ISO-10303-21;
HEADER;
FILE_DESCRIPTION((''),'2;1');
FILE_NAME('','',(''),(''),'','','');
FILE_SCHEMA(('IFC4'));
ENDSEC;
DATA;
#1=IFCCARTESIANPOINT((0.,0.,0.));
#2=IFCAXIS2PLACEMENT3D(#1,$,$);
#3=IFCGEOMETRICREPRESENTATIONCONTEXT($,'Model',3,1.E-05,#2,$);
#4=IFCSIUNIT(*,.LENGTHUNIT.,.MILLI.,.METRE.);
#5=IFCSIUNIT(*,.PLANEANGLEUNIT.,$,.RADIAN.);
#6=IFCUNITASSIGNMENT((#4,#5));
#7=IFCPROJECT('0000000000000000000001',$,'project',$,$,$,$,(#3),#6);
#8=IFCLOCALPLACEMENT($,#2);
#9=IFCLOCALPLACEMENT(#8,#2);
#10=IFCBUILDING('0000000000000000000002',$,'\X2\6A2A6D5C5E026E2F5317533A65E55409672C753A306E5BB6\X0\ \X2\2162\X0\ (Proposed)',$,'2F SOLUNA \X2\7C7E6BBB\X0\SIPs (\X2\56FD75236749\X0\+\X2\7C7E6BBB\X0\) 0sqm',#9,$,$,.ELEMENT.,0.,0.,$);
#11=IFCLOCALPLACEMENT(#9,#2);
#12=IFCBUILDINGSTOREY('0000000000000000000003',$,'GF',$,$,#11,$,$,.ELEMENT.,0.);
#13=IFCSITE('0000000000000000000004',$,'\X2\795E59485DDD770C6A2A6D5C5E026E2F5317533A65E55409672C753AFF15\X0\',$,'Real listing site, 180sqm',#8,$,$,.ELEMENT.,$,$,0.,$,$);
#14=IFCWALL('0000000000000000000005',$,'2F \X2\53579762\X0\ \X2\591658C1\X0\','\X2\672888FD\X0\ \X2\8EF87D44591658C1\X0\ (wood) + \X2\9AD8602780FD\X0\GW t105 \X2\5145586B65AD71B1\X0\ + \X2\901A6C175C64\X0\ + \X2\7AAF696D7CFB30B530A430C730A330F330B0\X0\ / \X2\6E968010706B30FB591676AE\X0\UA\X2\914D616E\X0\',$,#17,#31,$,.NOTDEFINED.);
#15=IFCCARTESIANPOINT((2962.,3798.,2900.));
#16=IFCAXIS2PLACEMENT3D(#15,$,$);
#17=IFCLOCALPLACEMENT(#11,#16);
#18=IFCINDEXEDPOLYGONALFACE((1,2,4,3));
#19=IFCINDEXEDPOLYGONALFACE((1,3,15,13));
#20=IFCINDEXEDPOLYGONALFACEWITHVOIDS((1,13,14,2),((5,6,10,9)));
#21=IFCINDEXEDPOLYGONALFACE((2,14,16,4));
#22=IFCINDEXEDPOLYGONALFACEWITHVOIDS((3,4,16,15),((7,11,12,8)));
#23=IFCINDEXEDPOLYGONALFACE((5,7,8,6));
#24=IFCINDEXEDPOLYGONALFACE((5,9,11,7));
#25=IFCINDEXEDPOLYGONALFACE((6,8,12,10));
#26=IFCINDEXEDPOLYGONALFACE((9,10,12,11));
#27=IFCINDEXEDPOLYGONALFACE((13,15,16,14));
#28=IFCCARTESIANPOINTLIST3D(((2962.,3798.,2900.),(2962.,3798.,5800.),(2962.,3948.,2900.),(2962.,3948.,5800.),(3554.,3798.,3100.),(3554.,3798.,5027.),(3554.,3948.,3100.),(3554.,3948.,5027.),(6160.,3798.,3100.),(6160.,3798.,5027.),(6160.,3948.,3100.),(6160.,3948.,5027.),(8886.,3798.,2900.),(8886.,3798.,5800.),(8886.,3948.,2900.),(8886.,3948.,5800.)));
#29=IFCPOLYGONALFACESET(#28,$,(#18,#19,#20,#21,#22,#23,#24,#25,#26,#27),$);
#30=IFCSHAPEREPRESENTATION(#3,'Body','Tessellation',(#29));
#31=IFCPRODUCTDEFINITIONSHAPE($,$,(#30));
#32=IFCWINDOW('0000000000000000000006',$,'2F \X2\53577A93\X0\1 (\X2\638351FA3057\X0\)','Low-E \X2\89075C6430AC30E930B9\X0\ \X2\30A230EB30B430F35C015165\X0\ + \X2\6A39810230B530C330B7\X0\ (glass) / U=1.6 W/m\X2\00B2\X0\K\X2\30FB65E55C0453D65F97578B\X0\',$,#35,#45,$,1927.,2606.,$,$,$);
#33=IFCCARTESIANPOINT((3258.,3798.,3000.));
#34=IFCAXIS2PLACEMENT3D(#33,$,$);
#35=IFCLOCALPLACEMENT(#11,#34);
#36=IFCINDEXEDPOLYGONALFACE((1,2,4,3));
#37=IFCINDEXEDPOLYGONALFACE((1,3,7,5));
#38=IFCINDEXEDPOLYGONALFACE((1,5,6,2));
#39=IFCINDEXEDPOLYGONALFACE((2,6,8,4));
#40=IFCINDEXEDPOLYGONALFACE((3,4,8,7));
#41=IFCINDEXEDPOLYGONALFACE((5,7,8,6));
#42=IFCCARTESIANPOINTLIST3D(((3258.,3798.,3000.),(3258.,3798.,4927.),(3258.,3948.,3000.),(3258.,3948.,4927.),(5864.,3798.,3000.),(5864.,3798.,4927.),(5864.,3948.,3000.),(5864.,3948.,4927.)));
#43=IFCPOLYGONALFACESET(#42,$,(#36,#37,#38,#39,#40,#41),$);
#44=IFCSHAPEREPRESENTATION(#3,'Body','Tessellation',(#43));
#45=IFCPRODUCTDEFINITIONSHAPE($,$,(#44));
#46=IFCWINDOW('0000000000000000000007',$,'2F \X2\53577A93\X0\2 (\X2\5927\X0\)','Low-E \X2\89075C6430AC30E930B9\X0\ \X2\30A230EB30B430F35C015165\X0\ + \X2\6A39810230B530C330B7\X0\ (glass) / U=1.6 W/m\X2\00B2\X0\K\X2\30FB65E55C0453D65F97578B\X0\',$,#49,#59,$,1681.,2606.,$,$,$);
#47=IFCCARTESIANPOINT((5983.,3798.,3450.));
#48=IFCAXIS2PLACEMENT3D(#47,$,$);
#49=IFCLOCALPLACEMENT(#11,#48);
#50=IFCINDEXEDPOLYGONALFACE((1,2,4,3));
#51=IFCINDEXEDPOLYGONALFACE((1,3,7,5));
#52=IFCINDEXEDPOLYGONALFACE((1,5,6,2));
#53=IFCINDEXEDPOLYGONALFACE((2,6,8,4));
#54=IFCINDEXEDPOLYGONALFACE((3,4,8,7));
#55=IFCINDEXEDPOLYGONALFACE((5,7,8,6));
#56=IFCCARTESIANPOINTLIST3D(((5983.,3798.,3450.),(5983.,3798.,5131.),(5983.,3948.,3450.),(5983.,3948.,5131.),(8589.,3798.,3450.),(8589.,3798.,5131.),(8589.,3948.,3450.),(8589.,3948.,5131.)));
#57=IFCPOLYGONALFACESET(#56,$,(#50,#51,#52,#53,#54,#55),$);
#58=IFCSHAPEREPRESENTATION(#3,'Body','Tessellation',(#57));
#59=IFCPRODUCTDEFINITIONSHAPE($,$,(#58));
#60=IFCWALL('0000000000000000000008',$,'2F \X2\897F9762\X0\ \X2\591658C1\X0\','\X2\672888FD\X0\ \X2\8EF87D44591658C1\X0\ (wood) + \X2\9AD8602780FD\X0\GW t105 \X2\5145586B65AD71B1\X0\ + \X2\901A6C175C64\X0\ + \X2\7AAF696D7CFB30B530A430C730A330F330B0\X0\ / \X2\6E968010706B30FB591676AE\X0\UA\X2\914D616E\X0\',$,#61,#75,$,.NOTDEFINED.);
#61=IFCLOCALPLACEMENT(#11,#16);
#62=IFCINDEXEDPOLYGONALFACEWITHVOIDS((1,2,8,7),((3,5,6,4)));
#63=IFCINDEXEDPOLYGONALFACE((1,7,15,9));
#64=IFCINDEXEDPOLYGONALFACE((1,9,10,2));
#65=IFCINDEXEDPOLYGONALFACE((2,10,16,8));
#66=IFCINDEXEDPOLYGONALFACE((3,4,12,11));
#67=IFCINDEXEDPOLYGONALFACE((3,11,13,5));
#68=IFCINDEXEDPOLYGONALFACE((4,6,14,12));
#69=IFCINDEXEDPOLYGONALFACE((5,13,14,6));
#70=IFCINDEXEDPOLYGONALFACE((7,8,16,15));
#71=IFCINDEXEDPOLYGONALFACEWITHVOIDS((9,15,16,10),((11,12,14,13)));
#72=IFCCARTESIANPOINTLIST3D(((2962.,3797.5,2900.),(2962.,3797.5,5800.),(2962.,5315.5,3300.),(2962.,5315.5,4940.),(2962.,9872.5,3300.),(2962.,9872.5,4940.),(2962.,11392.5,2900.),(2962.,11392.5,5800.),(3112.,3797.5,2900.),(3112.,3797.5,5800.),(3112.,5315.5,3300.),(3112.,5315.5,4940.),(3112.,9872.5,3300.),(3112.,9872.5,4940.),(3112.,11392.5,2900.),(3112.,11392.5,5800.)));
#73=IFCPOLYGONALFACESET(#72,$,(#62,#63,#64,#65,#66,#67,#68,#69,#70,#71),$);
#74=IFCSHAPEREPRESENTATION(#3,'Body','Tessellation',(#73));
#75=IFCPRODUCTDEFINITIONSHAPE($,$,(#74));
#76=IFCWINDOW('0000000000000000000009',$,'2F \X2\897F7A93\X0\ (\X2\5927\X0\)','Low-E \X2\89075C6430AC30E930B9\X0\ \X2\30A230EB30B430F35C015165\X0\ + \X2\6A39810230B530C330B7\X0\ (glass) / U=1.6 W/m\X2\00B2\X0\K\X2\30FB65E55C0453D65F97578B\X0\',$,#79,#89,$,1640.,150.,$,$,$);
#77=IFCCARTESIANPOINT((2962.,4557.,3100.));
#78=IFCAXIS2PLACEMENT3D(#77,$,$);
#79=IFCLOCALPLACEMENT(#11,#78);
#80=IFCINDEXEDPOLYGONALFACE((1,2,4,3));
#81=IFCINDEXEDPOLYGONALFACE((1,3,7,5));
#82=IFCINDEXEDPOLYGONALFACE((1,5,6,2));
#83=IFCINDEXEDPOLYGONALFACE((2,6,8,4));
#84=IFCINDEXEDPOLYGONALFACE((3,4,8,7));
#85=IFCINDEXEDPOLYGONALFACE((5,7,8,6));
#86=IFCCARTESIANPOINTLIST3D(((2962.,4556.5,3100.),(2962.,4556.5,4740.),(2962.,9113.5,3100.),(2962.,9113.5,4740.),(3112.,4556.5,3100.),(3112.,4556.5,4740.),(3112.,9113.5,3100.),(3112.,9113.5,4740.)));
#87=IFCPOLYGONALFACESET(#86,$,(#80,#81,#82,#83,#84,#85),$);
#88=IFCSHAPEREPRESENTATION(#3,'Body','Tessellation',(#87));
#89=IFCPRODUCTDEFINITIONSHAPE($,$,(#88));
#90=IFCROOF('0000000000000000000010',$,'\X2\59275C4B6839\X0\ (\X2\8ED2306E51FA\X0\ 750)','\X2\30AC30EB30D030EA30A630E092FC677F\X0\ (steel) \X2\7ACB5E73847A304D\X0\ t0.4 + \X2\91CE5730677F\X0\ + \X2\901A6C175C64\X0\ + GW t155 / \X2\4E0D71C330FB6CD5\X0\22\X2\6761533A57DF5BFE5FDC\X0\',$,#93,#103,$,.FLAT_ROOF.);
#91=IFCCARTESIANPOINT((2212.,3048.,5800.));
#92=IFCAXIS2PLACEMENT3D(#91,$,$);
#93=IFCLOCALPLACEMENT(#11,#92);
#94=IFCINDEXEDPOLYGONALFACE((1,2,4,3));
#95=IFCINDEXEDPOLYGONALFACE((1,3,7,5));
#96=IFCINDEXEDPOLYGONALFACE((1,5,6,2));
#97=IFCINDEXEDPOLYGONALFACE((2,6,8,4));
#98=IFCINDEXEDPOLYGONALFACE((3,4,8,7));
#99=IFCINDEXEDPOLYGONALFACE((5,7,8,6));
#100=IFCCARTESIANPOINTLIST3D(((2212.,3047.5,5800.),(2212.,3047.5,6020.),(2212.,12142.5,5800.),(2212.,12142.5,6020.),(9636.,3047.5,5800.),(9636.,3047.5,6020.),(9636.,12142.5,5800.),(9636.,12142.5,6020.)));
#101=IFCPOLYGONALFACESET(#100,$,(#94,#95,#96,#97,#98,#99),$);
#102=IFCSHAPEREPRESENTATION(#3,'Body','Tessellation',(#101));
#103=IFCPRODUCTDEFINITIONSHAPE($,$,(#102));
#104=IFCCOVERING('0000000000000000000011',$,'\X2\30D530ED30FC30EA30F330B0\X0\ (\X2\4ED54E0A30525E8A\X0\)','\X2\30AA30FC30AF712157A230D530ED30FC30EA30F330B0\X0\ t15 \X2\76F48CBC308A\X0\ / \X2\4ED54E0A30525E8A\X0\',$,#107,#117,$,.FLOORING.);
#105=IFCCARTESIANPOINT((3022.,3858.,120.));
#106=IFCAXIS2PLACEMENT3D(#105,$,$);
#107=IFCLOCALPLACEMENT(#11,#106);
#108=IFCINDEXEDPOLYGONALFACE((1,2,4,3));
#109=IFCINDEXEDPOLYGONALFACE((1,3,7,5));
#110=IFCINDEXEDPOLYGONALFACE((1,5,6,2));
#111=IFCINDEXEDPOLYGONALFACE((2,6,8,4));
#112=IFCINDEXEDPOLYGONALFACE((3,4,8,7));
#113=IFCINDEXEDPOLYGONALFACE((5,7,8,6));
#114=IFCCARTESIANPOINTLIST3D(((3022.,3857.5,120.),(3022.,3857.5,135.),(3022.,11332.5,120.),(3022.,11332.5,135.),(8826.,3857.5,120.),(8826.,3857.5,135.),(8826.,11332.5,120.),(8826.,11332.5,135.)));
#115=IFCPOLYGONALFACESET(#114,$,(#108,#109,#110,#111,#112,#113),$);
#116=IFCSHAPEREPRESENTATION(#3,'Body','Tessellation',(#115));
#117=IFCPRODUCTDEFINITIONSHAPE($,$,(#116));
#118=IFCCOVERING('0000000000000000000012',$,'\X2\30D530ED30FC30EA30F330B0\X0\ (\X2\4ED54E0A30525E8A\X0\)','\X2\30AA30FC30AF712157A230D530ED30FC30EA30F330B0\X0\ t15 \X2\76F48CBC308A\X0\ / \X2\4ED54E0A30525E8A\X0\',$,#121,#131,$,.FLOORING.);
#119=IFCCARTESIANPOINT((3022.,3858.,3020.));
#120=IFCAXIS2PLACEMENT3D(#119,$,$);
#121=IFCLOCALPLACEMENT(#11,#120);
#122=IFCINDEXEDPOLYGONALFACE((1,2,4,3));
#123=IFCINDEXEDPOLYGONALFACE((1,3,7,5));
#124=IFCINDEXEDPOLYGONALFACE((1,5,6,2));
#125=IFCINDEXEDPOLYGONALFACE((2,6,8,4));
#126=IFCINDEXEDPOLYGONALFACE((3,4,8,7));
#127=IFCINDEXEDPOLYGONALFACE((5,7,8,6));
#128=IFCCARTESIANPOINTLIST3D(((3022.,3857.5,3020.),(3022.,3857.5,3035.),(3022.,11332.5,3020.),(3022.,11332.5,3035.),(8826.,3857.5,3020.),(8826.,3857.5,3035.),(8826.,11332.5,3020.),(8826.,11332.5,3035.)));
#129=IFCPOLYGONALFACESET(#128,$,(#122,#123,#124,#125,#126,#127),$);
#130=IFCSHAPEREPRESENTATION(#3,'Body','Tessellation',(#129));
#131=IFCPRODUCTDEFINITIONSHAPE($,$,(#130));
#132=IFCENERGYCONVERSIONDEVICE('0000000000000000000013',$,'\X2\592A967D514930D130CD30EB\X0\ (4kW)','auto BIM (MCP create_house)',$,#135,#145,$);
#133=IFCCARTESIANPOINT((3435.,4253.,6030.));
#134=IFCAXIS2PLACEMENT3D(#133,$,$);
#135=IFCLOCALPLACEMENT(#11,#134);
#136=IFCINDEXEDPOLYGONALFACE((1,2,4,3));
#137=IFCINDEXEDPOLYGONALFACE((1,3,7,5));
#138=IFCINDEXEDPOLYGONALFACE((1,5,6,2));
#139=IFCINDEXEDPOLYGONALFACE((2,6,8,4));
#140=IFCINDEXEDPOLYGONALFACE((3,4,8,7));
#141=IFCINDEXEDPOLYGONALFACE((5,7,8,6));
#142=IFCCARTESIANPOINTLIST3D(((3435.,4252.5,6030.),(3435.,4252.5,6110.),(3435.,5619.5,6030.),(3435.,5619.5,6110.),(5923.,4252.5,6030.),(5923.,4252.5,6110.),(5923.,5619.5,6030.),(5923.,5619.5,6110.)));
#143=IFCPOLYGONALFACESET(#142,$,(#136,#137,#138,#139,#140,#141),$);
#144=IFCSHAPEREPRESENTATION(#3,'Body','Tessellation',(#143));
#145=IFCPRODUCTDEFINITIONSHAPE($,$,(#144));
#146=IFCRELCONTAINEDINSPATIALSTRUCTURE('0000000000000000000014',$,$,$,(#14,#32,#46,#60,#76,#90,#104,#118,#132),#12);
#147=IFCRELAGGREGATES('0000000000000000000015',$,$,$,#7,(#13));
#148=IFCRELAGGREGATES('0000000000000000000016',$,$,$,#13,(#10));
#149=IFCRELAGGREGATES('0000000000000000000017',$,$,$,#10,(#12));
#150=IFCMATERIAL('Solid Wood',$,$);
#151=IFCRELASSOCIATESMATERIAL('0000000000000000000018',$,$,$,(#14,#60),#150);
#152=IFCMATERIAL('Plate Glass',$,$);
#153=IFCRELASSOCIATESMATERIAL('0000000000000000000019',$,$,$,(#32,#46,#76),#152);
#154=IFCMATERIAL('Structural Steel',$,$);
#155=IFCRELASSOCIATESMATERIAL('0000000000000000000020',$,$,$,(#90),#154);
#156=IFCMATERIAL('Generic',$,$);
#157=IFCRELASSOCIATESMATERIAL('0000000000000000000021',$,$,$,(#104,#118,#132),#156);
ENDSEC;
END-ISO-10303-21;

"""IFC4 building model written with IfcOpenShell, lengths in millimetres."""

from ifc_helpers import new_model, si_unit, frame, frame_2d, origin, place, context, project, spatial, rectangle, extrude, material, element, fill, save


model = new_model("IFC4")

# Units and contexts
model_context = context("Model", 3, precision=1e-05, world=origin())
ifc_project = project(units=[si_unit("LENGTHUNIT", "METRE", prefix="MILLI"), si_unit("PLANEANGLEUNIT", "RADIAN")], contexts=[model_context])

# Site, building, storey
site_placement = place(None, origin())
site = spatial("IfcSite", under=ifc_project, at=site_placement, Name="神奈川県横浜市港北区日吉本町５", ObjectType="Real listing site, 180sqm", CompositionType="ELEMENT", RefElevation=0.0)
building_placement = place(site_placement, origin())
building = spatial("IfcBuilding", under=site, at=building_placement, Name="横浜市港北区日吉本町の家 Ⅲ (Proposed)", ObjectType="2F SOLUNA 籾殻SIPs (国産杉+籾殻) 0sqm", CompositionType="ELEMENT", ElevationOfRefHeight=0.0, ElevationOfTerrain=0.0)
storey_placement = place(building_placement, origin())
storey = spatial("IfcBuildingStorey", under=building, at=storey_placement, Name="GF", CompositionType="ELEMENT", Elevation=0.0)

# Shared definitions
ifc_material_1 = material(Name="Solid Wood")

# Shared definitions
ifc_material_2 = material(Name="Plate Glass")

# Wall, openings, windows
wall_1_placement = place(storey_placement, frame((2962.0, 3798.0, 2900.0)))
wall_1 = element("IfcWall", 1, at=wall_1_placement, inside=storey, material=ifc_material_1, Name="2F 南面 外壁", Description="木製 軸組外壁 (wood) + 高性能GW t105 充填断熱 + 通気層 + 窯業系サイディング / 準耐火・外皮UA配慮", PredefinedType="NOTDEFINED", context=model_context, shape_type="SweptSolid", body=[
    extrude(rectangle(XDim=5924.0, YDim=150.0, at=frame_2d((2962.0, 75.0))), frame((2962.0, 3798.0, 2900.0)), (0.0, 0.0, 1.0), 2900.0),
])
opening_1_placement = place(storey_placement, frame((3258.0, 3798.0, 3000.0)))
opening_1 = element("IfcOpeningElement", 2, at=opening_1_placement, cuts=wall_1, PredefinedType="NOTDEFINED", context=model_context, shape_type="SweptSolid", body=[
    extrude(rectangle(XDim=2606.0, YDim=150.0, at=frame_2d((1303.0, 75.0))), frame((3258.0, 3798.0, 3000.0)), (0.0, 0.0, 1.0), 1927.0),
])
opening_2_placement = place(storey_placement, frame((5983.0, 3798.0, 3450.0)))
opening_2 = element("IfcOpeningElement", 3, at=opening_2_placement, cuts=wall_1, PredefinedType="NOTDEFINED", context=model_context, shape_type="SweptSolid", body=[
    extrude(rectangle(XDim=2606.0, YDim=150.0, at=frame_2d((1303.0, 75.0))), frame((5983.0, 3798.0, 3450.0)), (0.0, 0.0, 1.0), 1681.0),
])
window_1_placement = place(storey_placement, frame((3258.0, 3798.0, 3000.0)))
window_1 = element("IfcWindow", 4, at=window_1_placement, inside=storey, material=ifc_material_2, Name="2F 南窓1 (掃出し)", Description="Low-E 複層ガラス アルゴン封入 + 樹脂サッシ (glass) / U=1.6 W/m²K・日射取得型", OverallHeight=1927.0, OverallWidth=2606.0, context=model_context, shape_type="SweptSolid", body=[
    extrude(rectangle(XDim=2606.0, YDim=150.0, at=frame_2d((1303.0, 75.0))), frame((3258.0, 3798.0, 3000.0)), (0.0, 0.0, 1.0), 1927.0),
])
fill(opening_1, window_1)
window_2_placement = place(storey_placement, frame((5983.0, 3798.0, 3450.0)))
window_2 = element("IfcWindow", 5, at=window_2_placement, inside=storey, material=ifc_material_2, Name="2F 南窓2 (大)", Description="Low-E 複層ガラス アルゴン封入 + 樹脂サッシ (glass) / U=1.6 W/m²K・日射取得型", OverallHeight=1681.0, OverallWidth=2606.0, context=model_context, shape_type="SweptSolid", body=[
    extrude(rectangle(XDim=2606.0, YDim=150.0, at=frame_2d((1303.0, 75.0))), frame((5983.0, 3798.0, 3450.0)), (0.0, 0.0, 1.0), 1681.0),
])
fill(opening_2, window_2)

# Wall, opening, window
wall_2_placement = place(storey_placement, frame((2962.0, 3798.0, 2900.0)))
wall_2 = element("IfcWall", 6, at=wall_2_placement, inside=storey, material=ifc_material_1, Name="2F 西面 外壁", Description="木製 軸組外壁 (wood) + 高性能GW t105 充填断熱 + 通気層 + 窯業系サイディング / 準耐火・外皮UA配慮", PredefinedType="NOTDEFINED", context=model_context, shape_type="SweptSolid", body=[
    extrude(rectangle(XDim=150.0, YDim=7595.0, at=frame_2d((75.0, 3797.0))), frame((2962.0, 3798.0, 2900.0)), (0.0, 0.0, 1.0), 2900.0),
])
opening_3_placement = place(storey_placement, frame((2962.0, 4557.0, 3100.0)))
opening_3 = element("IfcOpeningElement", 7, at=opening_3_placement, cuts=wall_2, PredefinedType="NOTDEFINED", context=model_context, shape_type="SweptSolid", body=[
    extrude(rectangle(XDim=150.0, YDim=4557.0, at=frame_2d((75.0, 2278.0))), frame((2962.0, 4557.0, 3100.0)), (0.0, 0.0, 1.0), 1640.0),
])
window_3_placement = place(storey_placement, frame((2962.0, 4557.0, 3100.0)))
window_3 = element("IfcWindow", 8, at=window_3_placement, inside=storey, material=ifc_material_2, Name="2F 西窓 (大)", Description="Low-E 複層ガラス アルゴン封入 + 樹脂サッシ (glass) / U=1.6 W/m²K・日射取得型", OverallHeight=1640.0, OverallWidth=150.0, context=model_context, shape_type="SweptSolid", body=[
    extrude(rectangle(XDim=150.0, YDim=4557.0, at=frame_2d((75.0, 2278.0))), frame((2962.0, 4557.0, 3100.0)), (0.0, 0.0, 1.0), 1640.0),
])
fill(opening_3, window_3)

# Roof
ifc_material_3 = material(Name="Structural Steel")
roof_placement = place(storey_placement, frame((2212.0, 3048.0, 5800.0)))
element("IfcRoof", 9, at=roof_placement, inside=storey, material=ifc_material_3, Name="大屋根 (軒の出 750)", Description="ガルバリウム鋼板 (steel) 立平葺き t0.4 + 野地板 + 通気層 + GW t155 / 不燃・法22条区域対応", PredefinedType="FLAT_ROOF", context=model_context, shape_type="SweptSolid", body=[
    extrude(rectangle(XDim=7424.0, YDim=9095.0, at=frame_2d((3712.0, 4547.0))), frame((2212.0, 3048.0, 5800.0)), (0.0, 0.0, 1.0), 220.0),
])

# Coverings
ifc_material_4 = material(Name="Generic")
covering_1_placement = place(storey_placement, frame((3022.0, 3858.0, 120.0)))
element("IfcCovering", 10, at=covering_1_placement, inside=storey, material=ifc_material_4, Name="フローリング (仕上げ床)", Description="オーク無垢フローリング t15 直貼り / 仕上げ床", PredefinedType="FLOORING", context=model_context, shape_type="SweptSolid", body=[
    extrude(rectangle(XDim=5804.0, YDim=7475.0, at=frame_2d((2902.0, 3737.0))), frame((3022.0, 3858.0, 120.0)), (0.0, 0.0, 1.0), 15.0),
])
covering_2_placement = place(storey_placement, frame((3022.0, 3858.0, 3020.0)))
element("IfcCovering", 11, at=covering_2_placement, inside=storey, material=ifc_material_4, Name="フローリング (仕上げ床)", Description="オーク無垢フローリング t15 直貼り / 仕上げ床", PredefinedType="FLOORING", context=model_context, shape_type="SweptSolid", body=[
    extrude(rectangle(XDim=5804.0, YDim=7475.0, at=frame_2d((2902.0, 3737.0))), frame((3022.0, 3858.0, 3020.0)), (0.0, 0.0, 1.0), 15.0),
])

# Energy conversion device
energy_conversion_device_placement = place(storey_placement, frame((3435.0, 4253.0, 6030.0)))
element("IfcEnergyConversionDevice", 12, at=energy_conversion_device_placement, inside=storey, material=ifc_material_4, Name="太陽光パネル (4kW)", Description="auto BIM (MCP create_house)", context=model_context, shape_type="SweptSolid", body=[
    extrude(rectangle(XDim=2488.0, YDim=1367.0, at=frame_2d((1244.0, 683.0))), frame((3435.0, 4253.0, 6030.0)), (0.0, 0.0, 1.0), 80.0),
])

save(model, "model.ifc")
